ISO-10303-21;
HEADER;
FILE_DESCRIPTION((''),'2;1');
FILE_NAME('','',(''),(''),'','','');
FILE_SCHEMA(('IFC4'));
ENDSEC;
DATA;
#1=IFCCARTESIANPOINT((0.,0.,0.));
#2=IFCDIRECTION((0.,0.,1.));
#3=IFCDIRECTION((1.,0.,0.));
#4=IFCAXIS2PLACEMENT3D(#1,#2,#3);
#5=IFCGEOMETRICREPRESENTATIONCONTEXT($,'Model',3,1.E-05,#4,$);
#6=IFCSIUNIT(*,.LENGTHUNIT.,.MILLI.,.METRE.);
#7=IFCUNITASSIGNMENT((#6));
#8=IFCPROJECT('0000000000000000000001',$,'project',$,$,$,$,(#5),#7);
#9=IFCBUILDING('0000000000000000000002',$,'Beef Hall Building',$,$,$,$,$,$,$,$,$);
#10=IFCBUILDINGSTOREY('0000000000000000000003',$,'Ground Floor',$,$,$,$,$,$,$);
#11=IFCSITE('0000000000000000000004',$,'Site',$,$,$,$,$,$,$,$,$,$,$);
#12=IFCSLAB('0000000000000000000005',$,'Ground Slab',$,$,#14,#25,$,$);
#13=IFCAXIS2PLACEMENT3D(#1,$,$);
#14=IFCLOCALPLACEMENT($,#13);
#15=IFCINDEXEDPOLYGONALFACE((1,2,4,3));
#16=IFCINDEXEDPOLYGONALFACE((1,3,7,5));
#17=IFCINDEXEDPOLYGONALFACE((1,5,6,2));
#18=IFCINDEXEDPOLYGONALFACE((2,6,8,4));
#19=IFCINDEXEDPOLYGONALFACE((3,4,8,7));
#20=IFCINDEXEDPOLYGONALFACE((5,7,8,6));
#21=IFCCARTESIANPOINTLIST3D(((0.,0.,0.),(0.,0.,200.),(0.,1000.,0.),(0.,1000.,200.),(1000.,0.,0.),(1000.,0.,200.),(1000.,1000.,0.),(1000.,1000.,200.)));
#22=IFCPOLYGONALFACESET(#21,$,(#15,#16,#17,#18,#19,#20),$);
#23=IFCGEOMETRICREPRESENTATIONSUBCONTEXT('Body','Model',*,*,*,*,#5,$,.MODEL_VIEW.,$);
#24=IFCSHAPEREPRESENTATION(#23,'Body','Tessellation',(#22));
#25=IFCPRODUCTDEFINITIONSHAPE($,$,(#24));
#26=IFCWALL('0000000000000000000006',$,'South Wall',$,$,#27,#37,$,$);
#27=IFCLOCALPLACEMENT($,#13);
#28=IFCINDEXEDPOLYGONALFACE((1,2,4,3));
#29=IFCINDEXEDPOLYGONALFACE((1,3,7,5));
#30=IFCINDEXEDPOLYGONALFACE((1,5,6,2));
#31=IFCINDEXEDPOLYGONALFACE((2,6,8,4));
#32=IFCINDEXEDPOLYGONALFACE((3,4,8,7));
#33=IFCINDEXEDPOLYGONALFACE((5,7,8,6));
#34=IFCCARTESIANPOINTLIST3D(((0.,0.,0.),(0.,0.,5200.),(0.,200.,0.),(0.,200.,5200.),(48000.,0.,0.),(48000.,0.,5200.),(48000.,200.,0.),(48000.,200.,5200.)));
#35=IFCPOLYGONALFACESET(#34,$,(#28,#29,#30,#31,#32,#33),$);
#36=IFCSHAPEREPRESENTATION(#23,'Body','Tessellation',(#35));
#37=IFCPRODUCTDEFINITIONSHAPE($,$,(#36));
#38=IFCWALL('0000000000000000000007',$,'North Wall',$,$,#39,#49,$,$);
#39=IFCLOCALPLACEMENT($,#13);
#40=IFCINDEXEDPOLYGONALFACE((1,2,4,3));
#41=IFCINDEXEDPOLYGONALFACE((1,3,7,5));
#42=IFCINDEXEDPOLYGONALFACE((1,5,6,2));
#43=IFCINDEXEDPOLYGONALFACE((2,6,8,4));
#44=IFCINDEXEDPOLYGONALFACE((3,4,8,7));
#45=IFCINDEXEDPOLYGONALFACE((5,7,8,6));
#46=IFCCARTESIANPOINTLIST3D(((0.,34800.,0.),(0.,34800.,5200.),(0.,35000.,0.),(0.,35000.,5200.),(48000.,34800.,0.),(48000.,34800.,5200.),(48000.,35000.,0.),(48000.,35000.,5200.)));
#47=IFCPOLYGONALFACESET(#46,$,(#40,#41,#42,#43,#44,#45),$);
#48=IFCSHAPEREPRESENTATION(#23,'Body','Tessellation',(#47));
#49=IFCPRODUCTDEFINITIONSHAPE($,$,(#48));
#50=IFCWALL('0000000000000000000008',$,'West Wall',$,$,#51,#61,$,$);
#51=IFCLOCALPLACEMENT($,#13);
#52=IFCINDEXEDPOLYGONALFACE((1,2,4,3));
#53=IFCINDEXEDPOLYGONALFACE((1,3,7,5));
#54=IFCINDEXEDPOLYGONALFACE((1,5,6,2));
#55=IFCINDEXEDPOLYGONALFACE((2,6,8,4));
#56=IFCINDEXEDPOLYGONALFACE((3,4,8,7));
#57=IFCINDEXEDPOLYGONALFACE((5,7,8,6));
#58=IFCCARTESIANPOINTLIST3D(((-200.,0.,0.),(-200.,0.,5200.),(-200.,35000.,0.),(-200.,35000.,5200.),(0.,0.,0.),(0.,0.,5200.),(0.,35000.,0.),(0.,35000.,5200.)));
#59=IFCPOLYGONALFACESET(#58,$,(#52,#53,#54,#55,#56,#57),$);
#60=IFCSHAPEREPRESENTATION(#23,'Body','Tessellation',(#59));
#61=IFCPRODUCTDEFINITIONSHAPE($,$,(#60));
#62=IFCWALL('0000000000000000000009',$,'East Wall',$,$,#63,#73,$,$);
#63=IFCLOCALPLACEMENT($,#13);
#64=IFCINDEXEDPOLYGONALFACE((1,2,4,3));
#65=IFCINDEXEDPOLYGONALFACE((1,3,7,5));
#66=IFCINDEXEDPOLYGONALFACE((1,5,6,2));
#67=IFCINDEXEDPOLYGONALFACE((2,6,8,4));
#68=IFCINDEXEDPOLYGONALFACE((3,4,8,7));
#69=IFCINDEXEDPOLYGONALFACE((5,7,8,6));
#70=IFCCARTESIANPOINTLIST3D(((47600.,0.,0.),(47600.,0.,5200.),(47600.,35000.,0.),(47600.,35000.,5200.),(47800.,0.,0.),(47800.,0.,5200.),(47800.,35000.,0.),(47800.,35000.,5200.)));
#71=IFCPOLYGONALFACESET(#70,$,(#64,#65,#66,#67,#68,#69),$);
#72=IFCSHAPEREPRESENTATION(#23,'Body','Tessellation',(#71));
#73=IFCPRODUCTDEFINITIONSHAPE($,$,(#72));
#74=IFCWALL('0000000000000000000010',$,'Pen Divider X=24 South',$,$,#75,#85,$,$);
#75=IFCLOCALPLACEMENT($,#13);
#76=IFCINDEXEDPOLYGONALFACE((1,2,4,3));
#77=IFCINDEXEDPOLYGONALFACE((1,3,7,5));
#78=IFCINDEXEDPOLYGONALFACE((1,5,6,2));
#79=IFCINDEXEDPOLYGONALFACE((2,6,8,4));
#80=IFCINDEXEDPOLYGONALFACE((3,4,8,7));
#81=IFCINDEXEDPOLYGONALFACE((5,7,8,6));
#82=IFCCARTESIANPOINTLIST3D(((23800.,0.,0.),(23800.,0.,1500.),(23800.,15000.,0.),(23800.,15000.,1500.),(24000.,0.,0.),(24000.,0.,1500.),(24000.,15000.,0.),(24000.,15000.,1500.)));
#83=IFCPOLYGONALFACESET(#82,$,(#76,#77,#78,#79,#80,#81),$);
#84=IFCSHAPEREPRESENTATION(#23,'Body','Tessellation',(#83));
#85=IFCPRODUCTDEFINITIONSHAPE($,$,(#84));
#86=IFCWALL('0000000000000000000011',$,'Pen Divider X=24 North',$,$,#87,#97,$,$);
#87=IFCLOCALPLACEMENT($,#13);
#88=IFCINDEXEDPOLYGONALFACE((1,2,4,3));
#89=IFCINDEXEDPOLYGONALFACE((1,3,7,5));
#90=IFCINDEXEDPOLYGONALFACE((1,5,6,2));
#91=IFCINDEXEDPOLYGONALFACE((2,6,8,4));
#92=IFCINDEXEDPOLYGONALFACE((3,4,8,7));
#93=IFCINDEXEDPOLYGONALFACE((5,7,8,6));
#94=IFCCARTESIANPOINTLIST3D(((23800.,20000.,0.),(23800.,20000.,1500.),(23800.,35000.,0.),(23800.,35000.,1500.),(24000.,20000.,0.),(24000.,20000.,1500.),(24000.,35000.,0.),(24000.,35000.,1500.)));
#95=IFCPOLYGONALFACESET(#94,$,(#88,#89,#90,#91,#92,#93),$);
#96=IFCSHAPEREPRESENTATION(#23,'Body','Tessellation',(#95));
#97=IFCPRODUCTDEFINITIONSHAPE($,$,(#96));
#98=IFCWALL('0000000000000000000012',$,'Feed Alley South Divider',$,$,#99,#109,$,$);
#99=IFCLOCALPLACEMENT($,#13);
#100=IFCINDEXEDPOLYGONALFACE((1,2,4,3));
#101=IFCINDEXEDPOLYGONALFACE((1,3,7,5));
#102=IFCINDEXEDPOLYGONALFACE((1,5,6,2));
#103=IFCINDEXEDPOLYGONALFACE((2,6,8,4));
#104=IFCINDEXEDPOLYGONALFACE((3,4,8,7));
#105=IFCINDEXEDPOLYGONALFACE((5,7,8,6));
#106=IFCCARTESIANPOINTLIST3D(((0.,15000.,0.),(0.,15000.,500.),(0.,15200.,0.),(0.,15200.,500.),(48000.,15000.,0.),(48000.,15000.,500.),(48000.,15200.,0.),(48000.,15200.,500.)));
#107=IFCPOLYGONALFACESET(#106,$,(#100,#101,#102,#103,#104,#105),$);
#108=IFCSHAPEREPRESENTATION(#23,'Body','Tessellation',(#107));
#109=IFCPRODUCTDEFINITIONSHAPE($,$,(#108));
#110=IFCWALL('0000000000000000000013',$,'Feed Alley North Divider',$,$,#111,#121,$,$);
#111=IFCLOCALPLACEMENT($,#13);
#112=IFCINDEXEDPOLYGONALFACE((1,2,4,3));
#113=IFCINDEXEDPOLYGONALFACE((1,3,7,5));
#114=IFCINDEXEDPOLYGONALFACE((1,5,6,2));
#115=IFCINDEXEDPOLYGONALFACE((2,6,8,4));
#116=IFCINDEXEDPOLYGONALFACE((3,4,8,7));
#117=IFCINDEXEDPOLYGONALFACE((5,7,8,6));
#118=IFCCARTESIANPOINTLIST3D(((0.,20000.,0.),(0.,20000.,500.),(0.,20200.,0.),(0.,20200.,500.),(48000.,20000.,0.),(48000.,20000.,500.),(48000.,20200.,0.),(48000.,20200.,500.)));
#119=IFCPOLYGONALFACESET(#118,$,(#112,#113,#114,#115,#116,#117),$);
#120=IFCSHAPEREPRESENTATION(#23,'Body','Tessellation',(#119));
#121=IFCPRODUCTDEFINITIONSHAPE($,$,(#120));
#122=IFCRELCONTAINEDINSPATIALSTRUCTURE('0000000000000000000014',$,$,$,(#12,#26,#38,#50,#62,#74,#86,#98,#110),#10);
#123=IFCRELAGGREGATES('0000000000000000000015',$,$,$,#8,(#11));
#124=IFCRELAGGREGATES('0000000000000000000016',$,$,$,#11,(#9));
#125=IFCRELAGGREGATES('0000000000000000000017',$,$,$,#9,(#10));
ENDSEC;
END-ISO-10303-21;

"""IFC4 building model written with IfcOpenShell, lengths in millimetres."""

from ifc_helpers import new_model, si_unit, frame, origin_with_axes, place, context, subcontext, project, spatial, indexed_curve, outline, extrude, element, save


model = new_model("IFC4")

# Units and contexts
model_context = context("Model", 3, precision=1e-05, world=origin_with_axes())
body_context = subcontext(model_context, "Body", "Model", "MODEL_VIEW")
ifc_project = project(units=[si_unit("LENGTHUNIT", "METRE", prefix="MILLI")], contexts=[model_context])

# Site, building, storey
site = spatial("IfcSite", under=ifc_project, Name="Site")
building = spatial("IfcBuilding", under=site, Name="Beef Hall Building")
storey = spatial("IfcBuildingStorey", under=building, Name="Ground Floor")

# Slab
slab_placement = place(None, origin_with_axes())
element("IfcSlab", 1, at=slab_placement, inside=storey, Name="Ground Slab", context=body_context, shape_type="SweptSolid", body=[
    extrude(outline(indexed_curve([(0.0, 0.0), (1000.0, 0.0), (1000.0, 1000.0), (0.0, 1000.0), (0.0, 0.0)])), None, (0.0, 0.0, 1.0), 200.0),
])

# Walls
for number, where, z_axis, x_axis, name in (
    (2, (0.0, 0.0, 0.0), (0.0, 0.0, 1.0), (1.0, 0.0, 0.0), "South Wall"),
    (3, (0.0, 34800.0, 0.0), (0.0, 0.0, 1.0), (1.0, 0.0, 0.0), "North Wall"),
):
    element("IfcWall", number, at=place(None, frame(where, z_axis=z_axis, x_axis=x_axis)), inside=storey, Name=name, context=body_context, shape_type="SweptSolid", body=[
        extrude(outline(indexed_curve([(0.0, 0.0), (0.0, 200.0), (48000.0, 200.0), (48000.0, 0.0), (0.0, 0.0)], self_intersect=False)), origin_with_axes(), (0.0, 0.0, 1.0), 5200.0),
    ])
for number, where, z_axis, x_axis, name in (
    (4, (0.0, 0.0, 0.0), (0.0, 0.0, 1.0), (0.0, 1.0, 0.0), "West Wall"),
    (5, (47800.0, 0.0, 0.0), (0.0, 0.0, 1.0), (0.0, 1.0, 0.0), "East Wall"),
):
    element("IfcWall", number, at=place(None, frame(where, z_axis=z_axis, x_axis=x_axis)), inside=storey, Name=name, context=body_context, shape_type="SweptSolid", body=[
        extrude(outline(indexed_curve([(0.0, 0.0), (0.0, 200.0), (35000.0, 200.0), (35000.0, 0.0), (0.0, 0.0)], self_intersect=False)), origin_with_axes(), (0.0, 0.0, 1.0), 5200.0),
    ])
for number, where, z_axis, x_axis, name in (
    (6, (24000.0, 0.0, 0.0), (0.0, 0.0, 1.0), (0.0, 1.0, 0.0), "Pen Divider X=24 South"),
    (7, (24000.0, 20000.0, 0.0), (0.0, 0.0, 1.0), (0.0, 1.0, 0.0), "Pen Divider X=24 North"),
):
    element("IfcWall", number, at=place(None, frame(where, z_axis=z_axis, x_axis=x_axis)), inside=storey, Name=name, context=body_context, shape_type="SweptSolid", body=[
        extrude(outline(indexed_curve([(0.0, 0.0), (0.0, 200.0), (15000.0, 200.0), (15000.0, 0.0), (0.0, 0.0)], self_intersect=False)), origin_with_axes(), (0.0, 0.0, 1.0), 1500.0),
    ])
for number, where, z_axis, x_axis, name in (
    (8, (0.0, 15000.0, 0.0), (0.0, 0.0, 1.0), (1.0, 0.0, 0.0), "Feed Alley South Divider"),
    (9, (0.0, 20000.0, 0.0), (0.0, 0.0, 1.0), (1.0, 0.0, 0.0), "Feed Alley North Divider"),
):
    element("IfcWall", number, at=place(None, frame(where, z_axis=z_axis, x_axis=x_axis)), inside=storey, Name=name, context=body_context, shape_type="SweptSolid", body=[
        extrude(outline(indexed_curve([(0.0, 0.0), (0.0, 200.0), (48000.0, 200.0), (48000.0, 0.0), (0.0, 0.0)], self_intersect=False)), origin_with_axes(), (0.0, 0.0, 1.0), 500.0),
    ])

save(model, "model.ifc")
